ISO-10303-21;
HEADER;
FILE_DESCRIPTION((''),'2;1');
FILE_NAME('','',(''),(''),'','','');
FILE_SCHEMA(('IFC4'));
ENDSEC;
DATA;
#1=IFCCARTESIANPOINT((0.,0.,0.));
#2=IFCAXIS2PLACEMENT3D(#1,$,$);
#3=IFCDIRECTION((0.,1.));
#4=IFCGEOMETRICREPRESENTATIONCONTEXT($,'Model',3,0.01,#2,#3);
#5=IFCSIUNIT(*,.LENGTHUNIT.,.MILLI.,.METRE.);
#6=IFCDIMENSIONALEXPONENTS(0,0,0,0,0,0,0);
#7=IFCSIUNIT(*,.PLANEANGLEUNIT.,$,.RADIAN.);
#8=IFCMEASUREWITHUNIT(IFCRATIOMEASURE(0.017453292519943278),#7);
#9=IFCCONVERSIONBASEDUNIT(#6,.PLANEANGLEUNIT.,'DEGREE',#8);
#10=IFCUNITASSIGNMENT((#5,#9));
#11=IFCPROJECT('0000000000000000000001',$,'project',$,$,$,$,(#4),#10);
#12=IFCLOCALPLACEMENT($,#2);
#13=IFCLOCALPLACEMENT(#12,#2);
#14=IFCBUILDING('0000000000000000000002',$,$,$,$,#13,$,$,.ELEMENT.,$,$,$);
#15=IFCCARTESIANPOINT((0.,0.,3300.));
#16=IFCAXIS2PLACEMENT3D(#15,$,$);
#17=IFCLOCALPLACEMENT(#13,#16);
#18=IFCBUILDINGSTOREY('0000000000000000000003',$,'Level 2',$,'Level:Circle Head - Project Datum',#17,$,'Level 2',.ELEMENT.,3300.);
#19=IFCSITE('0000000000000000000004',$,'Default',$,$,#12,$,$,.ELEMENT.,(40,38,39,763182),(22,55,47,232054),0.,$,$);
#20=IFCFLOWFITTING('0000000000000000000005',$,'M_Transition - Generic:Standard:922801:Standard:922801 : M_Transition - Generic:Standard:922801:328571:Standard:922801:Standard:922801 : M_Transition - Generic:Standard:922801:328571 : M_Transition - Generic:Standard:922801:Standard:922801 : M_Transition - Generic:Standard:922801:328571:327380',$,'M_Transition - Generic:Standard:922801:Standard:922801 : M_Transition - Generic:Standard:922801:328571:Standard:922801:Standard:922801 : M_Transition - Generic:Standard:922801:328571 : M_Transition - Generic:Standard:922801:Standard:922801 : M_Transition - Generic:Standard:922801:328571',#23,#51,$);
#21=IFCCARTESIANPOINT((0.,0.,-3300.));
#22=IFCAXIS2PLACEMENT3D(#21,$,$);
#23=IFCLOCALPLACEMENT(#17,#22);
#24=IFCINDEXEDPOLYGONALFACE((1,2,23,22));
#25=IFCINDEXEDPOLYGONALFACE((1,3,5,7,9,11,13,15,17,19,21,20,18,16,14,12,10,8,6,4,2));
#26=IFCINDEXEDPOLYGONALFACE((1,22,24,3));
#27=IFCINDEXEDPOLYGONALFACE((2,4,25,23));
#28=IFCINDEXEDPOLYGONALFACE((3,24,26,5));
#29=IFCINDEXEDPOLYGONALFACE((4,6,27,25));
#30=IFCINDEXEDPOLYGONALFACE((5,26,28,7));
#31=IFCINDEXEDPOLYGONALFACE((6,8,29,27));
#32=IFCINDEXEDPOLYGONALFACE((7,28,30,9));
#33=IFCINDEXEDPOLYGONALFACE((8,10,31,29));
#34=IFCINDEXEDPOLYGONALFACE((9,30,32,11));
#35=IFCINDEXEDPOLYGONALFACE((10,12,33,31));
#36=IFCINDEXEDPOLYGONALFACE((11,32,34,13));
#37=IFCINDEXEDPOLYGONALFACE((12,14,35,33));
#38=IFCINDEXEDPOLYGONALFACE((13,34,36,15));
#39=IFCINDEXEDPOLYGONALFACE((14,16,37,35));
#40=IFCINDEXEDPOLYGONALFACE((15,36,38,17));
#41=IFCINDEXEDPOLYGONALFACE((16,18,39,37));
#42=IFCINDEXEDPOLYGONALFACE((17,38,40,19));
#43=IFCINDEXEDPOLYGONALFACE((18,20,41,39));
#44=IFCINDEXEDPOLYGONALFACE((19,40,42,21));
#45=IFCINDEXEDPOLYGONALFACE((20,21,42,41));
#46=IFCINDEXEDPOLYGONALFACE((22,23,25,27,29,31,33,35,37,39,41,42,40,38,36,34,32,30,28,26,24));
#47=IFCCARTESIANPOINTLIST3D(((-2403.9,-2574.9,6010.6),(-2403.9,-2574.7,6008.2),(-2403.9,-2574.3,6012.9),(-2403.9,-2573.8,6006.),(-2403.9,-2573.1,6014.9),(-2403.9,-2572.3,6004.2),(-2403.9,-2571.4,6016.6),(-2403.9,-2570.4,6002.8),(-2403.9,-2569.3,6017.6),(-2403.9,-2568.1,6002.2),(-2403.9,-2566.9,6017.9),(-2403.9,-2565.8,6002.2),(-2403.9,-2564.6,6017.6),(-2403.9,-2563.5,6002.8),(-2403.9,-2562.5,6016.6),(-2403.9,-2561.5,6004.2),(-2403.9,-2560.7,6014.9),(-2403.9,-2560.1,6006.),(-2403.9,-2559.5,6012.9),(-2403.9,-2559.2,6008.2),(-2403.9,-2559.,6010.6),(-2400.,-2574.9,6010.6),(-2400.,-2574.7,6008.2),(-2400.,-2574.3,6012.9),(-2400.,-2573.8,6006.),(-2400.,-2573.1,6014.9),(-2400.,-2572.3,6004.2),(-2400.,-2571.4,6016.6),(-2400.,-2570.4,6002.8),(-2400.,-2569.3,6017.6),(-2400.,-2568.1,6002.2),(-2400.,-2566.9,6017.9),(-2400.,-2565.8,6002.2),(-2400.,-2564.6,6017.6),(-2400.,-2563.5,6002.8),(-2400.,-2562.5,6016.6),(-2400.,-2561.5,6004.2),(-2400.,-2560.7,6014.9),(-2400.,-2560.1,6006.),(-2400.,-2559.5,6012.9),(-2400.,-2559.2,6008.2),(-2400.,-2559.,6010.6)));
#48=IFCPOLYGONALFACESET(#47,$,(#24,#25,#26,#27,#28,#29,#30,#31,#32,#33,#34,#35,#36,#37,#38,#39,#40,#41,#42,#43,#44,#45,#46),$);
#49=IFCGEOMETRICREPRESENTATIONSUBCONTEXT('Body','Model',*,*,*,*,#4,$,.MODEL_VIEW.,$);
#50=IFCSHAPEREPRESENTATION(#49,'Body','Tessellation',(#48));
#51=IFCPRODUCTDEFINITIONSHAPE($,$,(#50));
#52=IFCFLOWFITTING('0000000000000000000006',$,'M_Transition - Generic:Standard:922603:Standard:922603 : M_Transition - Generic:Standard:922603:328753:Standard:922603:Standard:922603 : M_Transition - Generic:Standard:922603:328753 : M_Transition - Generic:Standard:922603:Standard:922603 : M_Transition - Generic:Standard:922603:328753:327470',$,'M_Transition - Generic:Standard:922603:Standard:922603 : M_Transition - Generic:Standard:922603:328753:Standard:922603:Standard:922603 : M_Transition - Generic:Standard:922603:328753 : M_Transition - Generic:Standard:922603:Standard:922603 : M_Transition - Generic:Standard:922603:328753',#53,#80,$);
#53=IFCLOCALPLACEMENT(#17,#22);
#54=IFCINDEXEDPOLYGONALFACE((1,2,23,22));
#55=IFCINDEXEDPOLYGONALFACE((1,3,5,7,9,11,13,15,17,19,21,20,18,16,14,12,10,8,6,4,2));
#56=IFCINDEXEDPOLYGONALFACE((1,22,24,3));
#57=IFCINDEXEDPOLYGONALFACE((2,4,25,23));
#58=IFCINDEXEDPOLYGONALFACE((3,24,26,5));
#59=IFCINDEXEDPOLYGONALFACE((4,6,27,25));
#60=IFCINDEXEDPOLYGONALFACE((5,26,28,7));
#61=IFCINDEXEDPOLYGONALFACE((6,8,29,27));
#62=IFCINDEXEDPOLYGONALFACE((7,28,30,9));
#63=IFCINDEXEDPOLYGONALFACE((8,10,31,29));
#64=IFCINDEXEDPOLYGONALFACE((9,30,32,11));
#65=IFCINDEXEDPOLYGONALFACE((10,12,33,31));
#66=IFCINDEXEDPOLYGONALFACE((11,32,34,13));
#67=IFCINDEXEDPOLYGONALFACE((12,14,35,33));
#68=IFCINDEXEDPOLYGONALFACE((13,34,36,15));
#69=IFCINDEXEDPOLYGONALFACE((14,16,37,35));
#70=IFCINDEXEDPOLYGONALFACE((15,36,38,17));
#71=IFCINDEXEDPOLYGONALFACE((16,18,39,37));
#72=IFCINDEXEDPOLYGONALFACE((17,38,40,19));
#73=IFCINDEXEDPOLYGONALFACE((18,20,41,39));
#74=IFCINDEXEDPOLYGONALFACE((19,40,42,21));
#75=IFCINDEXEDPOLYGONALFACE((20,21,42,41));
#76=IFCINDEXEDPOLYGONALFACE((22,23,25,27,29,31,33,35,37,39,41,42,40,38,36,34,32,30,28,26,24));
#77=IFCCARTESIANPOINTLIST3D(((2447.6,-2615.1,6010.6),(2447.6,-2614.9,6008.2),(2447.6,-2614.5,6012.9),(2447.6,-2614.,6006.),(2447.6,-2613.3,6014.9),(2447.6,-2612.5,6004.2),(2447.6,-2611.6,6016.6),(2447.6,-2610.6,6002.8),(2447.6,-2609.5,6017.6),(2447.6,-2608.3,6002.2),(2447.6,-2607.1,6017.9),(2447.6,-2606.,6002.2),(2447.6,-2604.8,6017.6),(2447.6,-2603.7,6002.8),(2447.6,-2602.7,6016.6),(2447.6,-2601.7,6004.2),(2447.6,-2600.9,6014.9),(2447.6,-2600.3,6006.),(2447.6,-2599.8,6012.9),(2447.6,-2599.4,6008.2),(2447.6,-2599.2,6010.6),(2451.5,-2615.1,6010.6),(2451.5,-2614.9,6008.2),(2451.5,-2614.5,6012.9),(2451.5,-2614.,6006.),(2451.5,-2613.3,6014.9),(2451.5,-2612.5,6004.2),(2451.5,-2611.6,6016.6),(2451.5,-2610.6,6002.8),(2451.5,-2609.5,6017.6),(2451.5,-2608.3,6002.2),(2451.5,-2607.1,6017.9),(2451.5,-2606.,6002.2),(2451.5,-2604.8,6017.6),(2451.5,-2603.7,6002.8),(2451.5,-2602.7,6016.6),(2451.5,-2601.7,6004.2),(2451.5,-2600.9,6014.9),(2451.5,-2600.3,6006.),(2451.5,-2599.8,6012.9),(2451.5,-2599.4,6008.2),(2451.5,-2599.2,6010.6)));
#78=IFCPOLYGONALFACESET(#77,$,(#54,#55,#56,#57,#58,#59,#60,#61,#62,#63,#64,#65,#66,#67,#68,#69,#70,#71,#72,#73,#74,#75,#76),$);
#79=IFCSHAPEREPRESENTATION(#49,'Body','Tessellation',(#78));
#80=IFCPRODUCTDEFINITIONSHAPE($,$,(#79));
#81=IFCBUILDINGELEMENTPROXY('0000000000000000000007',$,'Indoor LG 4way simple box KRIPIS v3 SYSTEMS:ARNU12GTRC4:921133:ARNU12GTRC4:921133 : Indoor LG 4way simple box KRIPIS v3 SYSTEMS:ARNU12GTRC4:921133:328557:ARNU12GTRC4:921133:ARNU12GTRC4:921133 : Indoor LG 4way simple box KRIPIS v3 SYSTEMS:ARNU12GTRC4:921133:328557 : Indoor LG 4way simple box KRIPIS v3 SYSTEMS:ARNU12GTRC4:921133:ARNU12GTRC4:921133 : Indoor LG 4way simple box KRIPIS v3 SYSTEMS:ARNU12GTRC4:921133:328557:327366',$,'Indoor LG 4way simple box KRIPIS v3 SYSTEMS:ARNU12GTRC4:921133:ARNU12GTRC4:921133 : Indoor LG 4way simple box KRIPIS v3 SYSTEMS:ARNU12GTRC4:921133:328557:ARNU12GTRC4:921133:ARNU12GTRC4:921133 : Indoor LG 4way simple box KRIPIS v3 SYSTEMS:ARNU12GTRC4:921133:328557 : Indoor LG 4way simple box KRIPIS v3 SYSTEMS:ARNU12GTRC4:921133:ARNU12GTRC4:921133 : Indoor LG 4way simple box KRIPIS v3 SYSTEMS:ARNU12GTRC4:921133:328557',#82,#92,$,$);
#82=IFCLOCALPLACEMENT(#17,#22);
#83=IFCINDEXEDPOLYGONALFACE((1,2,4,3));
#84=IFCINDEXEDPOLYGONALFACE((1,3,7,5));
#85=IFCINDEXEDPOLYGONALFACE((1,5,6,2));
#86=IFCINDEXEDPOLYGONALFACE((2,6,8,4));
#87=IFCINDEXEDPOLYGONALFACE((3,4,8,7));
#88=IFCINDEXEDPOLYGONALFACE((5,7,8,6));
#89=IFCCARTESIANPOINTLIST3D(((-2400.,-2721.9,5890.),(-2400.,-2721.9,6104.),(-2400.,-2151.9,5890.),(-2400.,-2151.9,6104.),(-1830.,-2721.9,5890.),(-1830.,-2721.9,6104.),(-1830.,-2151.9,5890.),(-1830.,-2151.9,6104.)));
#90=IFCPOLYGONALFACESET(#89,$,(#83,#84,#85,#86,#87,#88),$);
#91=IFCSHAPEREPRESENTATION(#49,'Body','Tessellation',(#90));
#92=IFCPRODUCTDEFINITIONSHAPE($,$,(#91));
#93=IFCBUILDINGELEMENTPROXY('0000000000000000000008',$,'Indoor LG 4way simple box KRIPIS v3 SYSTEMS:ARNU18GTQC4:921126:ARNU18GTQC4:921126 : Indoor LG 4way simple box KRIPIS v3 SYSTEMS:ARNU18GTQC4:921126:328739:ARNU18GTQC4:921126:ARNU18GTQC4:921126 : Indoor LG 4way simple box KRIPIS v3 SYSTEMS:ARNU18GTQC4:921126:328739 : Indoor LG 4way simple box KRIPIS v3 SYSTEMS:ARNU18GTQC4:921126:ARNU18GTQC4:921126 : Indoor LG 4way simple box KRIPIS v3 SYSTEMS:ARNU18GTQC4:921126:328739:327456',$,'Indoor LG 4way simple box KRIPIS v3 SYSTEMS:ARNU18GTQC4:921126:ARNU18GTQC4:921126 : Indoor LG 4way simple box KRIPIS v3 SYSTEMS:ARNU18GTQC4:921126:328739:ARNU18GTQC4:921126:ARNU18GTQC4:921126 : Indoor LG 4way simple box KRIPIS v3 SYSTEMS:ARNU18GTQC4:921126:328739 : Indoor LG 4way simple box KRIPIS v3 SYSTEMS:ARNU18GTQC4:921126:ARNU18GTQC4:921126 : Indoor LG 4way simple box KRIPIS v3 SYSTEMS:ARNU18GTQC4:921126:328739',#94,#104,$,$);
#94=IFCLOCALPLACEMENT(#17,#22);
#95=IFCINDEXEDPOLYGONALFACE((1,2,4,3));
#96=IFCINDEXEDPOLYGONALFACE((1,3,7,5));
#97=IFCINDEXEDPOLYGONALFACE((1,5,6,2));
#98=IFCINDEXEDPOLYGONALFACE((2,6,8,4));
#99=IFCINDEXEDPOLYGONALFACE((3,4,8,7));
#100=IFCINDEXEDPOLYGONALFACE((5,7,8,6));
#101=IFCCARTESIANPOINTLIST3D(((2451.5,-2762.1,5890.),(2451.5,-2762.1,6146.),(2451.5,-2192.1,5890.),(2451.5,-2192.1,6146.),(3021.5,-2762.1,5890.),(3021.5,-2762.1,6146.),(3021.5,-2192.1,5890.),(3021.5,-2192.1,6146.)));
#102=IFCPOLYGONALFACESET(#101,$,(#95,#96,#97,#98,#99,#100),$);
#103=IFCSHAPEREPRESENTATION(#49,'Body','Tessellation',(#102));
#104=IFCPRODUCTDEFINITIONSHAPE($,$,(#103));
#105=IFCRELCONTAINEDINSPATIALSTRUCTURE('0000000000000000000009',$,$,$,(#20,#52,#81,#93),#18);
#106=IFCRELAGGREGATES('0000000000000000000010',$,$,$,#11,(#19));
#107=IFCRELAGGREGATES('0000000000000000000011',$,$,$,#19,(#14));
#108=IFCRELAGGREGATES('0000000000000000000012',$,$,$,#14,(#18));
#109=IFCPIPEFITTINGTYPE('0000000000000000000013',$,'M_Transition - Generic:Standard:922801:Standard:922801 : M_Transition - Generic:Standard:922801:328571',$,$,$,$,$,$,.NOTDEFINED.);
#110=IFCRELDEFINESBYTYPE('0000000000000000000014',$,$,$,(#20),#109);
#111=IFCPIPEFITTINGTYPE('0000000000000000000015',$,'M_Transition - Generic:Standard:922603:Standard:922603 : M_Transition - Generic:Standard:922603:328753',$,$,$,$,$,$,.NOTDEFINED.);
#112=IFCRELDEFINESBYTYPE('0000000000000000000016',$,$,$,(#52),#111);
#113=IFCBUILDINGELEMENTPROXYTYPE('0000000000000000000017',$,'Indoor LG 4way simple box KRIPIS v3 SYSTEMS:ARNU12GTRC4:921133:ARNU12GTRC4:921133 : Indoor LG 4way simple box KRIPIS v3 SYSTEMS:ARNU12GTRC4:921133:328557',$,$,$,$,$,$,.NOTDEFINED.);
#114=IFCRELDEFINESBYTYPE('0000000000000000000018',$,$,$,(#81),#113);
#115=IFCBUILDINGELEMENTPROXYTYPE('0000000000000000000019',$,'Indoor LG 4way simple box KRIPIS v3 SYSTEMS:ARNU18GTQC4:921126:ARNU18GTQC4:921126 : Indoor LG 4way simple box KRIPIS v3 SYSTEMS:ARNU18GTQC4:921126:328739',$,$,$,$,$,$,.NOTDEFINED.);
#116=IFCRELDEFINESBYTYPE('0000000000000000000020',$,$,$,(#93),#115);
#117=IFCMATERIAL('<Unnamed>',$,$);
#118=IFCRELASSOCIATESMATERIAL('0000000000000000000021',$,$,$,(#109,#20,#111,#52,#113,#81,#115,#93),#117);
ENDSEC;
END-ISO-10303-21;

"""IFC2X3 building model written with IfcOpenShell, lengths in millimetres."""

from ifc_helpers import new_model, entity, si_unit, converted_unit, direction, frame, frame_2d, origin, origin_2d_with_axis, place, context, subcontext, project, spatial, rectangle, circle, extrude, source, transform, mapped, material, type_object, type_shapes, element, save


model = new_model("IFC2X3")

# Units and contexts
model_context = context("Model", 3, precision=0.01, world=origin(), true_north=direction((0.0, 1.0)))
body_context = subcontext(model_context, "Body", "Model", "MODEL_VIEW")
ifc_project = project(units=[si_unit("LENGTHUNIT", "METRE", prefix="MILLI"), converted_unit("PLANEANGLEUNIT", "DEGREE", entity("IfcRatioMeasure", 0.017453292519943278), si_unit("PLANEANGLEUNIT", "RADIAN"), dimensions=[0, 0, 0, 0, 0, 0, 0])], contexts=[model_context])

# Site, building, storey
site_placement = place(None, origin())
site = spatial("IfcSite", under=ifc_project, at=site_placement, Name="Default", CompositionType="ELEMENT", RefLatitude=(40, 38, 39, 763182), RefLongitude=(22, 55, 47, 232054), RefElevation=0.0)
building_placement = place(site_placement, origin())
building = spatial("IfcBuilding", under=site, at=building_placement, CompositionType="ELEMENT")
storey_placement = place(building_placement, frame((0.0, 0.0, 3300.0)))
storey = spatial("IfcBuildingStorey", under=building, at=storey_placement, Name="Level 2", ObjectType="Level:Circle Head - Project Datum", LongName="Level 2", CompositionType="ELEMENT", Elevation=3300.0)

# Flow fittings
ifc_material_1 = material(Name="<Unnamed>")
pipe_fitting_type_1 = type_object("IfcPipeFittingType", Name="M_Transition - Generic:Standard:922801:Standard:922801 : M_Transition - Generic:Standard:922801:328571", PredefinedType="NOTDEFINED", material=ifc_material_1)
shared_shape_1 = source(origin(), body_context, "Body", "SweptSolid", [
    extrude(circle(Radius=7.9, at=origin_2d_with_axis()), frame((-2403.9, -2566.9, 6010.0), z_axis=(1.0, 0.0, 0.0), x_axis=(0.0, 0.0, 1.0)), (0.0, 0.0, 1.0), 4.0),
])
type_shapes(pipe_fitting_type_1, [shared_shape_1])
flow_fitting_1_placement = place(storey_placement, frame((0.0, 0.0, -3300.0)))
element("IfcFlowFitting", 1, at=flow_fitting_1_placement, inside=storey, type_object=pipe_fitting_type_1, material=ifc_material_1, Name="M_Transition - Generic:Standard:922801:Standard:922801 : M_Transition - Generic:Standard:922801:328571:Standard:922801:Standard:922801 : M_Transition - Generic:Standard:922801:328571 : M_Transition - Generic:Standard:922801:Standard:922801 : M_Transition - Generic:Standard:922801:328571:327380", ObjectType="M_Transition - Generic:Standard:922801:Standard:922801 : M_Transition - Generic:Standard:922801:328571:Standard:922801:Standard:922801 : M_Transition - Generic:Standard:922801:328571 : M_Transition - Generic:Standard:922801:Standard:922801 : M_Transition - Generic:Standard:922801:328571", context=body_context, shape_type="MappedRepresentation", body=[
    mapped(shared_shape_1, transform((0.0, 0.0, 0.0), scale=1.0)),
])
pipe_fitting_type_2 = type_object("IfcPipeFittingType", Name="M_Transition - Generic:Standard:922603:Standard:922603 : M_Transition - Generic:Standard:922603:328753", PredefinedType="NOTDEFINED", material=ifc_material_1)
shared_shape_2 = source(origin(), body_context, "Body", "SweptSolid", [
    extrude(circle(Radius=7.9, at=origin_2d_with_axis()), frame((2447.6, -2607.1, 6010.0), z_axis=(1.0, 0.0, 0.0), x_axis=(0.0, 0.0, 1.0)), (0.0, 0.0, 1.0), 4.0),
])
type_shapes(pipe_fitting_type_2, [shared_shape_2])
flow_fitting_2_placement = place(storey_placement, frame((0.0, 0.0, -3300.0)))
element("IfcFlowFitting", 2, at=flow_fitting_2_placement, inside=storey, type_object=pipe_fitting_type_2, material=ifc_material_1, Name="M_Transition - Generic:Standard:922603:Standard:922603 : M_Transition - Generic:Standard:922603:328753:Standard:922603:Standard:922603 : M_Transition - Generic:Standard:922603:328753 : M_Transition - Generic:Standard:922603:Standard:922603 : M_Transition - Generic:Standard:922603:328753:327470", ObjectType="M_Transition - Generic:Standard:922603:Standard:922603 : M_Transition - Generic:Standard:922603:328753:Standard:922603:Standard:922603 : M_Transition - Generic:Standard:922603:328753 : M_Transition - Generic:Standard:922603:Standard:922603 : M_Transition - Generic:Standard:922603:328753", context=body_context, shape_type="MappedRepresentation", body=[
    mapped(shared_shape_2, transform((0.0, 0.0, 0.0), scale=1.0)),
])

# Building element proxies
building_element_proxy_type_1 = type_object("IfcBuildingElementProxyType", Name="Indoor LG 4way simple box KRIPIS v3 SYSTEMS:ARNU12GTRC4:921133:ARNU12GTRC4:921133 : Indoor LG 4way simple box KRIPIS v3 SYSTEMS:ARNU12GTRC4:921133:328557", PredefinedType="NOTDEFINED", material=ifc_material_1)
shared_shape_3 = source(origin(), body_context, "Body", "SweptSolid", [
    extrude(rectangle(XDim=570.0, YDim=570.0, at=origin_2d_with_axis()), frame((-2115.0, -2436.9, 5890.0), z_axis=(0.0, 0.0, 1.0), x_axis=(0.0, 1.0, 0.0)), (0.0, 0.0, 1.0), 214.0),
])
type_shapes(building_element_proxy_type_1, [shared_shape_3])
proxy_1_placement = place(storey_placement, frame((0.0, 0.0, -3300.0)))
element("IfcBuildingElementProxy", 3, at=proxy_1_placement, inside=storey, type_object=building_element_proxy_type_1, material=ifc_material_1, Name="Indoor LG 4way simple box KRIPIS v3 SYSTEMS:ARNU12GTRC4:921133:ARNU12GTRC4:921133 : Indoor LG 4way simple box KRIPIS v3 SYSTEMS:ARNU12GTRC4:921133:328557:ARNU12GTRC4:921133:ARNU12GTRC4:921133 : Indoor LG 4way simple box KRIPIS v3 SYSTEMS:ARNU12GTRC4:921133:328557 : Indoor LG 4way simple box KRIPIS v3 SYSTEMS:ARNU12GTRC4:921133:ARNU12GTRC4:921133 : Indoor LG 4way simple box KRIPIS v3 SYSTEMS:ARNU12GTRC4:921133:328557:327366", ObjectType="Indoor LG 4way simple box KRIPIS v3 SYSTEMS:ARNU12GTRC4:921133:ARNU12GTRC4:921133 : Indoor LG 4way simple box KRIPIS v3 SYSTEMS:ARNU12GTRC4:921133:328557:ARNU12GTRC4:921133:ARNU12GTRC4:921133 : Indoor LG 4way simple box KRIPIS v3 SYSTEMS:ARNU12GTRC4:921133:328557 : Indoor LG 4way simple box KRIPIS v3 SYSTEMS:ARNU12GTRC4:921133:ARNU12GTRC4:921133 : Indoor LG 4way simple box KRIPIS v3 SYSTEMS:ARNU12GTRC4:921133:328557", context=body_context, shape_type="MappedRepresentation", body=[
    mapped(shared_shape_3, transform((0.0, 0.0, 0.0), scale=1.0)),
])
building_element_proxy_type_2 = type_object("IfcBuildingElementProxyType", Name="Indoor LG 4way simple box KRIPIS v3 SYSTEMS:ARNU18GTQC4:921126:ARNU18GTQC4:921126 : Indoor LG 4way simple box KRIPIS v3 SYSTEMS:ARNU18GTQC4:921126:328739", PredefinedType="NOTDEFINED", material=ifc_material_1)
shared_shape_4 = source(origin(), body_context, "Body", "SweptSolid", [
    extrude(rectangle(XDim=570.0, YDim=570.0, at=frame_2d((0.0, 0.0), x_axis=(1.0, 0.0))), frame((2736.5, -2477.1, 5890.0), z_axis=(0.0, 0.0, 1.0), x_axis=(0.0, 1.0, 0.0)), (0.0, 0.0, 1.0), 256.0),
])
type_shapes(building_element_proxy_type_2, [shared_shape_4])
proxy_2_placement = place(storey_placement, frame((0.0, 0.0, -3300.0)))
element("IfcBuildingElementProxy", 4, at=proxy_2_placement, inside=storey, type_object=building_element_proxy_type_2, material=ifc_material_1, Name="Indoor LG 4way simple box KRIPIS v3 SYSTEMS:ARNU18GTQC4:921126:ARNU18GTQC4:921126 : Indoor LG 4way simple box KRIPIS v3 SYSTEMS:ARNU18GTQC4:921126:328739:ARNU18GTQC4:921126:ARNU18GTQC4:921126 : Indoor LG 4way simple box KRIPIS v3 SYSTEMS:ARNU18GTQC4:921126:328739 : Indoor LG 4way simple box KRIPIS v3 SYSTEMS:ARNU18GTQC4:921126:ARNU18GTQC4:921126 : Indoor LG 4way simple box KRIPIS v3 SYSTEMS:ARNU18GTQC4:921126:328739:327456", ObjectType="Indoor LG 4way simple box KRIPIS v3 SYSTEMS:ARNU18GTQC4:921126:ARNU18GTQC4:921126 : Indoor LG 4way simple box KRIPIS v3 SYSTEMS:ARNU18GTQC4:921126:328739:ARNU18GTQC4:921126:ARNU18GTQC4:921126 : Indoor LG 4way simple box KRIPIS v3 SYSTEMS:ARNU18GTQC4:921126:328739 : Indoor LG 4way simple box KRIPIS v3 SYSTEMS:ARNU18GTQC4:921126:ARNU18GTQC4:921126 : Indoor LG 4way simple box KRIPIS v3 SYSTEMS:ARNU18GTQC4:921126:328739", context=body_context, shape_type="MappedRepresentation", body=[
    mapped(shared_shape_4, transform((0.0, 0.0, 0.0), scale=1.0)),
])

save(model, "model.ifc")
